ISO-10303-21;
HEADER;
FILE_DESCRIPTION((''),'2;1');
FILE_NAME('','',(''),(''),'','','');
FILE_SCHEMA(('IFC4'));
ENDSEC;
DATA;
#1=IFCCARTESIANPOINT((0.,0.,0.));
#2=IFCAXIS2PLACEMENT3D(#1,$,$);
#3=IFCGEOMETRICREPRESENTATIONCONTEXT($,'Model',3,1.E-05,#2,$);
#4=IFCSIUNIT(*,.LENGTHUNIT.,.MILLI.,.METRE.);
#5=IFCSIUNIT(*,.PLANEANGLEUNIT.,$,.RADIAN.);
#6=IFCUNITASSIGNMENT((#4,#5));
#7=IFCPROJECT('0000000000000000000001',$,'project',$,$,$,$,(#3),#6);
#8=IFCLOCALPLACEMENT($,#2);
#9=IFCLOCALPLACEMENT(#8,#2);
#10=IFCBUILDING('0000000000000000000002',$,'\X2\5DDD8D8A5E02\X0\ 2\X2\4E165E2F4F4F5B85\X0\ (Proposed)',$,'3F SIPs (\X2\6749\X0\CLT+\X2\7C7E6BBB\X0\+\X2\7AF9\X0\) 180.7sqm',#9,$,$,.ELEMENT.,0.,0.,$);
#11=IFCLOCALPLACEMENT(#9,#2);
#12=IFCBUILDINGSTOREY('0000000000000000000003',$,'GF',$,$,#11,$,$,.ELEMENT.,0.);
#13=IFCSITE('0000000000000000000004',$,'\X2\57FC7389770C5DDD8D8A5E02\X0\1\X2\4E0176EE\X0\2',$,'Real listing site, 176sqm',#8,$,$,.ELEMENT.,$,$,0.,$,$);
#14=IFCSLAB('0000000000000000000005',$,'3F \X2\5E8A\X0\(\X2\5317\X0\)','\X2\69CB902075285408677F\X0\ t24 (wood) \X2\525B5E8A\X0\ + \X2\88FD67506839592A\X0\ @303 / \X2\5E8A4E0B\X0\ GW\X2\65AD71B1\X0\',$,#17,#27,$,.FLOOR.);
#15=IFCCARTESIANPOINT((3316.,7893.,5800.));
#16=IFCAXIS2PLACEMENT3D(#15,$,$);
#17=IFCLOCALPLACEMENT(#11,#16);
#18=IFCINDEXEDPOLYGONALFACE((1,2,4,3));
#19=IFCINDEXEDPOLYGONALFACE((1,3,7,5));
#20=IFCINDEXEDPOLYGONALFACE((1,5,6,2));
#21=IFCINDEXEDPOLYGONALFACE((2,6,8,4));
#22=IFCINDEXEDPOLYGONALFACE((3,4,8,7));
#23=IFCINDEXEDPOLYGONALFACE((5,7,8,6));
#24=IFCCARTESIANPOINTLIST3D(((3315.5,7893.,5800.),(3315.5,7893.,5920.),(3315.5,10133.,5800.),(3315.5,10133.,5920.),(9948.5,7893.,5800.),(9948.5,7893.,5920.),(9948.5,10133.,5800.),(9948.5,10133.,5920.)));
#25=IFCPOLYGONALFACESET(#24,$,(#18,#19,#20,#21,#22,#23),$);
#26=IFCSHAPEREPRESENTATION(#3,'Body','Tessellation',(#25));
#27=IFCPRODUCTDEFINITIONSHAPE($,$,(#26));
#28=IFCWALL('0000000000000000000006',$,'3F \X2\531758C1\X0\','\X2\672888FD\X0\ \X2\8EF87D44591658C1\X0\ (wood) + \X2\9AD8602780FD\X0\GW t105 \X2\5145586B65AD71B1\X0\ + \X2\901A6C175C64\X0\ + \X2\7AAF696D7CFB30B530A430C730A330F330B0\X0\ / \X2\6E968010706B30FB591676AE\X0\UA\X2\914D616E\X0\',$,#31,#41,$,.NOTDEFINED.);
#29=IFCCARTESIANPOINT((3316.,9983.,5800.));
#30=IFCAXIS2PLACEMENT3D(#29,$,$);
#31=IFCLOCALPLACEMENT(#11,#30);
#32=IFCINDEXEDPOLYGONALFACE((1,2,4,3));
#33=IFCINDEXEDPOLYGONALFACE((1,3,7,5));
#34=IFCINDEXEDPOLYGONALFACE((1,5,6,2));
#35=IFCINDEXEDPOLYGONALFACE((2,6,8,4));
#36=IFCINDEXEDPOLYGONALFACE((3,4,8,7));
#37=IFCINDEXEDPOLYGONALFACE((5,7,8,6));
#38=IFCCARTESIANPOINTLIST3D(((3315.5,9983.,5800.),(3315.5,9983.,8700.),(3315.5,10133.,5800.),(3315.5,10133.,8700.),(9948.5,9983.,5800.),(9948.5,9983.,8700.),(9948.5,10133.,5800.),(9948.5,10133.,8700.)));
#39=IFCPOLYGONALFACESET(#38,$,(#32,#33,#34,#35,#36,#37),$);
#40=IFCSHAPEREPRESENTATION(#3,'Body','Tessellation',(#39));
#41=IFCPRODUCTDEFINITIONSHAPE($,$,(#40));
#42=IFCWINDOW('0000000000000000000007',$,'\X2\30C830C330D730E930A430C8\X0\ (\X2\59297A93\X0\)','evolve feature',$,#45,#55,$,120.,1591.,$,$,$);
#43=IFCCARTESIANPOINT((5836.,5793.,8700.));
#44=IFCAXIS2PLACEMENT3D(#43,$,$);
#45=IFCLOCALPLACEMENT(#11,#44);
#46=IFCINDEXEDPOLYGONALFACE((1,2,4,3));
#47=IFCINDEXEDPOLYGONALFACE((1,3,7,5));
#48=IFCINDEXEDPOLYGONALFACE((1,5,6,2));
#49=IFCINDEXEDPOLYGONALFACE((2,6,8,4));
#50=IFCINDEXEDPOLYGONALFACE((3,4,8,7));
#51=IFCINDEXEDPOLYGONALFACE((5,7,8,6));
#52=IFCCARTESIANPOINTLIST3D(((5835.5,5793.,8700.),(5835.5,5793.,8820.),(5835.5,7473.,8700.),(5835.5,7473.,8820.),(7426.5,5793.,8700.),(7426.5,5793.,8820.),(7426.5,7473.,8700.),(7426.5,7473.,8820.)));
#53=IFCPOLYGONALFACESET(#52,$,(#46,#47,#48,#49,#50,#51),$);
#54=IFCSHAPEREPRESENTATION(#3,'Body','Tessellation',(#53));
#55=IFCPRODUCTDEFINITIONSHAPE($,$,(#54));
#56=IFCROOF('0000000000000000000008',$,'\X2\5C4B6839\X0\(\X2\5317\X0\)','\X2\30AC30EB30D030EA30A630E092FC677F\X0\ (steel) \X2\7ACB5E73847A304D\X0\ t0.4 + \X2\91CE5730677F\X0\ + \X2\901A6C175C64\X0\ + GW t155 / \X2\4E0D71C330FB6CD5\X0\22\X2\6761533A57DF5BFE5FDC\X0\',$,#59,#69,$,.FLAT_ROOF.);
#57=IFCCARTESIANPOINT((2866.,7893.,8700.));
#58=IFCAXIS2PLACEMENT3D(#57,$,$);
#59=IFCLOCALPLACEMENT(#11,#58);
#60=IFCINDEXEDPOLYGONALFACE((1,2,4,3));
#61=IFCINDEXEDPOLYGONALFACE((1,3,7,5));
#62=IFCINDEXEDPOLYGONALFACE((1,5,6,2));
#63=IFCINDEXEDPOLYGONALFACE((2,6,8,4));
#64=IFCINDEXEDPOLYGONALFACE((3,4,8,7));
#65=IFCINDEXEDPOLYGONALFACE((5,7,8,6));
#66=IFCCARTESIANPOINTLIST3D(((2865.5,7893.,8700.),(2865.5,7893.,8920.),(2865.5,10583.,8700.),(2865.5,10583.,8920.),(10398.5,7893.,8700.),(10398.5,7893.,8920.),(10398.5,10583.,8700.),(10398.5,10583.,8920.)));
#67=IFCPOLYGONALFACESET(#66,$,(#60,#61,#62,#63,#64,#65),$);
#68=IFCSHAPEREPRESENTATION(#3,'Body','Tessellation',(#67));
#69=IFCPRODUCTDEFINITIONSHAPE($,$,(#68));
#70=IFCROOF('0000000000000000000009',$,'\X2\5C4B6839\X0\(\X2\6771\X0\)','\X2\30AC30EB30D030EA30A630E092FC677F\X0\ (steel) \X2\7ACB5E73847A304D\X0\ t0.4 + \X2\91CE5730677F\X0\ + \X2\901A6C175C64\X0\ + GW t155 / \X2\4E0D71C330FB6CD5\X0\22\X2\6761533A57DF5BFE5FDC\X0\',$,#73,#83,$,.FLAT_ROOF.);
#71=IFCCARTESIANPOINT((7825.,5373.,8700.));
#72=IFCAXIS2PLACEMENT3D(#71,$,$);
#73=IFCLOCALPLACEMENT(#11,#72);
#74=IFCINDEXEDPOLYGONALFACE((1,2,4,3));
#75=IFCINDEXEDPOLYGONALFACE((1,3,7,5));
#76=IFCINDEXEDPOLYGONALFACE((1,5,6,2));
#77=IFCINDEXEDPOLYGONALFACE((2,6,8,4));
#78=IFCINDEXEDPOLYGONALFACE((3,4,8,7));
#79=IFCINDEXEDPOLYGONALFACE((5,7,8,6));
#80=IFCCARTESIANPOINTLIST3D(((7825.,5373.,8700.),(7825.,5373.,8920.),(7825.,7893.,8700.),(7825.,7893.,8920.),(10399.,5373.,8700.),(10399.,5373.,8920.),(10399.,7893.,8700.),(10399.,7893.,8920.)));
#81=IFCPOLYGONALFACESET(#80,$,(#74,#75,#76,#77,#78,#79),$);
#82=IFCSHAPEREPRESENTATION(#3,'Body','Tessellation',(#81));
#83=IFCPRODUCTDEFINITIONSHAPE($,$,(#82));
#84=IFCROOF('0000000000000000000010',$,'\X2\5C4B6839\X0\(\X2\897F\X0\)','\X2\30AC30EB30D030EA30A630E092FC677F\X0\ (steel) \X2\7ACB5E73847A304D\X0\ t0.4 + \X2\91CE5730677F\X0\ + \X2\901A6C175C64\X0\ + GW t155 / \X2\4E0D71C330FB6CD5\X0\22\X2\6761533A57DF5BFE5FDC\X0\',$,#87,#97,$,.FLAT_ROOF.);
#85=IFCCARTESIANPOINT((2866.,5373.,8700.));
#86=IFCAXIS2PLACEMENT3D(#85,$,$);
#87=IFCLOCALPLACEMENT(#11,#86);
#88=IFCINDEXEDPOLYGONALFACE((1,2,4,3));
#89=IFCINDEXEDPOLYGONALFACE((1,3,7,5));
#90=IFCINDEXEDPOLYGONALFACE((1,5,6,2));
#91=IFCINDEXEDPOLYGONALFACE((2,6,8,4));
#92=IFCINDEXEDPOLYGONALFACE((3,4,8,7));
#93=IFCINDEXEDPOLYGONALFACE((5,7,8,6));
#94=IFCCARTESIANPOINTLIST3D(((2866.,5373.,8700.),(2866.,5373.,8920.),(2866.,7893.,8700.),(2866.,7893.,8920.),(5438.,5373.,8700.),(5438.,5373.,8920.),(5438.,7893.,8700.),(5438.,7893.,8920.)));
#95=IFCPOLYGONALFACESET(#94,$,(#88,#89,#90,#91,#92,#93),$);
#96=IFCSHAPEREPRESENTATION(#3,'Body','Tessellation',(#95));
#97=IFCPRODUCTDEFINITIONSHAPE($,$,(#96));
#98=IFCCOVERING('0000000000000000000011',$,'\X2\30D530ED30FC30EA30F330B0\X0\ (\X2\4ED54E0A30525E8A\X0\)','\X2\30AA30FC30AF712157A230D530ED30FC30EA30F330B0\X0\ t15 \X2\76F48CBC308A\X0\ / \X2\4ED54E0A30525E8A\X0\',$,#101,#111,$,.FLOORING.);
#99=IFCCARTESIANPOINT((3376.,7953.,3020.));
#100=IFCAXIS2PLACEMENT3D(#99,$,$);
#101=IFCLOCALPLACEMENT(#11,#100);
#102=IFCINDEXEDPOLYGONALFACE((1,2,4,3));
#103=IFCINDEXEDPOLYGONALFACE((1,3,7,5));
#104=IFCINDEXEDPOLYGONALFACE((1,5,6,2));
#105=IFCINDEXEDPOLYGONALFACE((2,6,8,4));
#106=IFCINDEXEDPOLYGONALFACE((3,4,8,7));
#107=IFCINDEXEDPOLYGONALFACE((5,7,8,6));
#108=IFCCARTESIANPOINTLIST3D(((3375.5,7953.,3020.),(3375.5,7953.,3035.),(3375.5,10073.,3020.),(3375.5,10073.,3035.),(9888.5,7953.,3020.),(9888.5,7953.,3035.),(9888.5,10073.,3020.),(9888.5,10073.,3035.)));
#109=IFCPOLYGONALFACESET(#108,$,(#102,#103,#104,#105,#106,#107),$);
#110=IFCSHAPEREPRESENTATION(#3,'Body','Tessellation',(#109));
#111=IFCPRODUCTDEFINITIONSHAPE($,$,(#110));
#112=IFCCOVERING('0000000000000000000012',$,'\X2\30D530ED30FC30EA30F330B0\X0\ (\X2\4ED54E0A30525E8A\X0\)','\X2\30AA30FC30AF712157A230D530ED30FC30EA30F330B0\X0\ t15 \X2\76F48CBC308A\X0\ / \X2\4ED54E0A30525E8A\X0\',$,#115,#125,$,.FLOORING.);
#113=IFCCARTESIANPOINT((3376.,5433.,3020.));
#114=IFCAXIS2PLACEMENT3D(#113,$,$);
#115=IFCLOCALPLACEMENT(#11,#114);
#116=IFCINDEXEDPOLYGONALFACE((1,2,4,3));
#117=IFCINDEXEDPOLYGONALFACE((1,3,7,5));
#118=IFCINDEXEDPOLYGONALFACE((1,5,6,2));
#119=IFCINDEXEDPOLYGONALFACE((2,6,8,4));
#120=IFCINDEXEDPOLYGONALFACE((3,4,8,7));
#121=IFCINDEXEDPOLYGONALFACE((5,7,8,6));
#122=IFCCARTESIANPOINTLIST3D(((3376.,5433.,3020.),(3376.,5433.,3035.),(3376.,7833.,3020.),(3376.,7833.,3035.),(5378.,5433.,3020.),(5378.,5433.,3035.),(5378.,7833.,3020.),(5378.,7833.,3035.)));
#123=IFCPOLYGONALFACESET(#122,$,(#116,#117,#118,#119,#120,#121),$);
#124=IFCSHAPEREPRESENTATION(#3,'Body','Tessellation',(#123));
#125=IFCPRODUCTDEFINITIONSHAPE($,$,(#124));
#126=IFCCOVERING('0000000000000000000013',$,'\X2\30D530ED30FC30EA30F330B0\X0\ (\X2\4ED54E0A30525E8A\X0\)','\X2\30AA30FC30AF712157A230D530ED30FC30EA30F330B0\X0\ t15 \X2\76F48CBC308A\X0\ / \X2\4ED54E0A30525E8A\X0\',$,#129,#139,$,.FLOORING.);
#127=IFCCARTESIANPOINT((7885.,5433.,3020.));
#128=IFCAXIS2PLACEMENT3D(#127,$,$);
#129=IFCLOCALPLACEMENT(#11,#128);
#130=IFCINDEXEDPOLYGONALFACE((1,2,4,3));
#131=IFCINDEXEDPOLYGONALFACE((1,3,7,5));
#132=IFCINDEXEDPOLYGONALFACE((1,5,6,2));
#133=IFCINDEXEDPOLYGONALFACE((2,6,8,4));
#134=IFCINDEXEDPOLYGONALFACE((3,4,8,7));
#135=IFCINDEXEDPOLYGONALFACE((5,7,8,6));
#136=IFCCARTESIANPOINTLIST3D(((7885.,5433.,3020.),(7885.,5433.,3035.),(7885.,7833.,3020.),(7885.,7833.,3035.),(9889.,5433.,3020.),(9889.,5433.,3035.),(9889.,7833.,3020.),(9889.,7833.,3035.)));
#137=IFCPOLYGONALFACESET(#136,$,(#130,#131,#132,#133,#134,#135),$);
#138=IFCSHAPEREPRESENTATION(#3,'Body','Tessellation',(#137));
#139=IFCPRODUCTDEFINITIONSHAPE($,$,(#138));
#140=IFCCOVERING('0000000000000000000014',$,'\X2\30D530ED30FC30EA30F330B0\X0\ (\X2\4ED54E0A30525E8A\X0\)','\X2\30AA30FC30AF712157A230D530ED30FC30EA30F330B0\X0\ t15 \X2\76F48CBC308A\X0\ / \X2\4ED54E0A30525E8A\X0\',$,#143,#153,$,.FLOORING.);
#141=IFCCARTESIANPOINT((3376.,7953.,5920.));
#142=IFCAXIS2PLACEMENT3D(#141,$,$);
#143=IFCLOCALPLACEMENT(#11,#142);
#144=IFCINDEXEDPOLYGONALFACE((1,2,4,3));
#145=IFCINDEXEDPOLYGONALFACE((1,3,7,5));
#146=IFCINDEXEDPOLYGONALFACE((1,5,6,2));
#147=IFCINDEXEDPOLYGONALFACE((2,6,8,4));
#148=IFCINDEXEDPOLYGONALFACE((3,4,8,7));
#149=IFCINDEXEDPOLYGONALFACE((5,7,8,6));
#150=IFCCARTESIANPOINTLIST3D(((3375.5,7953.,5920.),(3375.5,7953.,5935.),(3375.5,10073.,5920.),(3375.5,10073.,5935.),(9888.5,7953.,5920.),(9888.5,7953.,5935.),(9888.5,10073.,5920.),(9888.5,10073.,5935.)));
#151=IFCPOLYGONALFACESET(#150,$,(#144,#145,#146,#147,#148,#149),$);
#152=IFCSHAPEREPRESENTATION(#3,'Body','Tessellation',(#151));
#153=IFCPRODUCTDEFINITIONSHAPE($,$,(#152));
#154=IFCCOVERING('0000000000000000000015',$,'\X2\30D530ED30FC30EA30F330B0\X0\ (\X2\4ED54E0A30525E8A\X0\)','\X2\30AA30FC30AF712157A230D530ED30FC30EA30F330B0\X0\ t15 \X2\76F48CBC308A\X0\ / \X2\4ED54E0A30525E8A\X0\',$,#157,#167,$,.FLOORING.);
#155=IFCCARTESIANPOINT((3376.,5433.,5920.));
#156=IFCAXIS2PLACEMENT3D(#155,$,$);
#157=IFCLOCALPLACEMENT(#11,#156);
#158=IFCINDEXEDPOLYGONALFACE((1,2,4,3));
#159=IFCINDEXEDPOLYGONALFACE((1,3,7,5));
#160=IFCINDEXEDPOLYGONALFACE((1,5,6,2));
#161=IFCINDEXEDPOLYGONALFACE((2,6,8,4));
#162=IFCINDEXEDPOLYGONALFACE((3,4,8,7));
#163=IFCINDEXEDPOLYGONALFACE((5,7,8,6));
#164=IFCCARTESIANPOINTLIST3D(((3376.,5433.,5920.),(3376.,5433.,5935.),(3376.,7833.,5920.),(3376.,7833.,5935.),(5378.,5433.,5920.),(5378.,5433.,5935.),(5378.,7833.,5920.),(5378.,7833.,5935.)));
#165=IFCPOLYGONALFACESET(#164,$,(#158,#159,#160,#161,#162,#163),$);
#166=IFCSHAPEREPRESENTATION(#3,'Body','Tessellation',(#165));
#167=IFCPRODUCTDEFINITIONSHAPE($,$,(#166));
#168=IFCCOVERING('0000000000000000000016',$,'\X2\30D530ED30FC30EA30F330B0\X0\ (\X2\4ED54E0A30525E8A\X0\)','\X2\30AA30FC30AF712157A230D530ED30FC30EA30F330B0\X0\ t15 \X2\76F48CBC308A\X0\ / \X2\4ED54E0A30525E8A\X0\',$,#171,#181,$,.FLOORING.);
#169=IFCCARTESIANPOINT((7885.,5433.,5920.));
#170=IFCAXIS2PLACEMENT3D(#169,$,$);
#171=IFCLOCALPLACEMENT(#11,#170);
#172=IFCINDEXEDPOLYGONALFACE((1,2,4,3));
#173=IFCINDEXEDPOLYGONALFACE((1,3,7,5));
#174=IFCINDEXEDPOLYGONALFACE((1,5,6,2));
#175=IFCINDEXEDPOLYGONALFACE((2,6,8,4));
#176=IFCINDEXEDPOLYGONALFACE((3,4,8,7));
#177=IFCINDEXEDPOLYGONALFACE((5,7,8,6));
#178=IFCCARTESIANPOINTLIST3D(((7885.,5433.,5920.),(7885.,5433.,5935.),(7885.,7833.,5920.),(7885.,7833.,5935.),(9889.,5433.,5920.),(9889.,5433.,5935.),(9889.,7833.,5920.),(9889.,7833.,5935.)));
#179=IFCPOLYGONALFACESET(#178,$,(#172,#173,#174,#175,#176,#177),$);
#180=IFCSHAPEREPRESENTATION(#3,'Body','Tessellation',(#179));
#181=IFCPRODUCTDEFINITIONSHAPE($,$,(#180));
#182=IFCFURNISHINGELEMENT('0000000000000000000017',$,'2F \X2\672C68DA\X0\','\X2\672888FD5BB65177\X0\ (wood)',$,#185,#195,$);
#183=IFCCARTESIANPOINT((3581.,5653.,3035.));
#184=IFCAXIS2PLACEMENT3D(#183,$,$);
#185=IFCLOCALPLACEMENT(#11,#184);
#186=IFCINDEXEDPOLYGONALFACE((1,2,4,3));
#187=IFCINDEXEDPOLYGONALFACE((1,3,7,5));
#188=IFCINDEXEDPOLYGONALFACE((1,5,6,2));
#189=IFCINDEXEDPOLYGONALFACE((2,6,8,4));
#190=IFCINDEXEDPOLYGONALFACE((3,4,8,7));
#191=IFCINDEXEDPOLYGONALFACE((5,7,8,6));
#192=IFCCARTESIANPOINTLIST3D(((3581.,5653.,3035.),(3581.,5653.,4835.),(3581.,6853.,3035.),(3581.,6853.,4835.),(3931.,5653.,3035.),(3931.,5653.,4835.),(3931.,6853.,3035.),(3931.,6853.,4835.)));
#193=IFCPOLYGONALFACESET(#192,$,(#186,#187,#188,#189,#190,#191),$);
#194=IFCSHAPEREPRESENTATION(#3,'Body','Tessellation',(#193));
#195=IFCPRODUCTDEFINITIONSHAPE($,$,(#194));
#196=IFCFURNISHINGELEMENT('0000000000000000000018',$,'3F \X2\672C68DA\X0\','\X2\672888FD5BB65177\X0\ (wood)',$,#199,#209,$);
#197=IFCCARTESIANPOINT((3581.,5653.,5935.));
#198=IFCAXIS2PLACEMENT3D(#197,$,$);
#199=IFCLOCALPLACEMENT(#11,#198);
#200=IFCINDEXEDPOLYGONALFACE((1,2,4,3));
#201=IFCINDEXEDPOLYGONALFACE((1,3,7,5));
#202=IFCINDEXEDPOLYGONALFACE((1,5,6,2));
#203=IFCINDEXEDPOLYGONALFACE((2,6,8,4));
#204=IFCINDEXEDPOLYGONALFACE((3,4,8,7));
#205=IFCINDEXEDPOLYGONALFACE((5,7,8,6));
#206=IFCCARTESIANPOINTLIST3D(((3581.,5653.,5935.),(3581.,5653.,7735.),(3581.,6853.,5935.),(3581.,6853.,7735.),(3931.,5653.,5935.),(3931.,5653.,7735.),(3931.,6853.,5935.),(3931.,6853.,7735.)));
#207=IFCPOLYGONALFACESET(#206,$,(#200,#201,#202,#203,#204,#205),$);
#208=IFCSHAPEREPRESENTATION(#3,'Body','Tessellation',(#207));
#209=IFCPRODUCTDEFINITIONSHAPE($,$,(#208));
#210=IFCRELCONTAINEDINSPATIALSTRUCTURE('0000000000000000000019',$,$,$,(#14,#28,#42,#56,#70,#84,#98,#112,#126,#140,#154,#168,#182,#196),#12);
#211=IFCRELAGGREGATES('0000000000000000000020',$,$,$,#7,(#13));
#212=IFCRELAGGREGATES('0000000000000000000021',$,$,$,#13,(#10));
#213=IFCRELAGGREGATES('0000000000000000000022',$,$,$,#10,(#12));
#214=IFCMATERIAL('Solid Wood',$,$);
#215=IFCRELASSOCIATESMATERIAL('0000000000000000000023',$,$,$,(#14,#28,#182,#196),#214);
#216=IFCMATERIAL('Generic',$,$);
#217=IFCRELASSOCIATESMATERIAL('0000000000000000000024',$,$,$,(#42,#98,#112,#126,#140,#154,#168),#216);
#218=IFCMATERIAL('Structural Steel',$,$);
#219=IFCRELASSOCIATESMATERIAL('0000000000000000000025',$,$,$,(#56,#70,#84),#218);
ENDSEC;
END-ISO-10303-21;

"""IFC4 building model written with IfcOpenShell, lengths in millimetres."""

from ifc_helpers import new_model, si_unit, frame, frame_2d, origin, place, context, project, spatial, rectangle, extrude, material, element, save


model = new_model("IFC4")

# Units and contexts
model_context = context("Model", 3, precision=1e-05, world=origin())
ifc_project = project(units=[si_unit("LENGTHUNIT", "METRE", prefix="MILLI"), si_unit("PLANEANGLEUNIT", "RADIAN")], contexts=[model_context])

# Site, building, storey
site_placement = place(None, origin())
site = spatial("IfcSite", under=ifc_project, at=site_placement, Name="埼玉県川越市1丁目2", ObjectType="Real listing site, 176sqm", CompositionType="ELEMENT", RefElevation=0.0)
building_placement = place(site_placement, origin())
building = spatial("IfcBuilding", under=site, at=building_placement, Name="川越市 2世帯住宅 (Proposed)", ObjectType="3F SIPs (杉CLT+籾殻+竹) 180.7sqm", CompositionType="ELEMENT", ElevationOfRefHeight=0.0, ElevationOfTerrain=0.0)
storey_placement = place(building_placement, origin())
storey = spatial("IfcBuildingStorey", under=building, at=storey_placement, Name="GF", CompositionType="ELEMENT", Elevation=0.0)

# Slab
ifc_material_1 = material(Name="Solid Wood")
slab_placement = place(storey_placement, frame((3316.0, 7893.0, 5800.0)))
element("IfcSlab", 1, at=slab_placement, inside=storey, material=ifc_material_1, Name="3F 床(北)", Description="構造用合板 t24 (wood) 剛床 + 製材根太 @303 / 床下 GW断熱", PredefinedType="FLOOR", context=model_context, shape_type="SweptSolid", body=[
    extrude(rectangle(XDim=6633.0, YDim=2240.0, at=frame_2d((3316.0, 1120.0))), frame((3316.0, 7893.0, 5800.0)), (0.0, 0.0, 1.0), 120.0),
])

# Wall
wall_1_placement = place(storey_placement, frame((3316.0, 9983.0, 5800.0)))
element("IfcWall", 2, at=wall_1_placement, inside=storey, material=ifc_material_1, Name="3F 北壁", Description="木製 軸組外壁 (wood) + 高性能GW t105 充填断熱 + 通気層 + 窯業系サイディング / 準耐火・外皮UA配慮", PredefinedType="NOTDEFINED", context=model_context, shape_type="SweptSolid", body=[
    extrude(rectangle(XDim=6633.0, YDim=150.0, at=frame_2d((3316.0, 75.0))), frame((3316.0, 9983.0, 5800.0)), (0.0, 0.0, 1.0), 2900.0),
])

# Window
ifc_material_2 = material(Name="Generic")
window_1_placement = place(storey_placement, frame((5836.0, 5793.0, 8700.0)))
element("IfcWindow", 3, at=window_1_placement, inside=storey, material=ifc_material_2, Name="トップライト (天窓)", Description="evolve feature", OverallHeight=120.0, OverallWidth=1591.0, context=model_context, shape_type="SweptSolid", body=[
    extrude(rectangle(XDim=1591.0, YDim=1680.0, at=frame_2d((795.0, 840.0))), frame((5836.0, 5793.0, 8700.0)), (0.0, 0.0, 1.0), 120.0),
])

# Roofs
ifc_material_3 = material(Name="Structural Steel")
roof_1_placement = place(storey_placement, frame((2866.0, 7893.0, 8700.0)))
element("IfcRoof", 4, at=roof_1_placement, inside=storey, material=ifc_material_3, Name="屋根(北)", Description="ガルバリウム鋼板 (steel) 立平葺き t0.4 + 野地板 + 通気層 + GW t155 / 不燃・法22条区域対応", PredefinedType="FLAT_ROOF", context=model_context, shape_type="SweptSolid", body=[
    extrude(rectangle(XDim=7533.0, YDim=2690.0, at=frame_2d((3766.0, 1345.0))), frame((2866.0, 7893.0, 8700.0)), (0.0, 0.0, 1.0), 220.0),
])
roof_2_placement = place(storey_placement, frame((7825.0, 5373.0, 8700.0)))
element("IfcRoof", 5, at=roof_2_placement, inside=storey, material=ifc_material_3, Name="屋根(東)", Description="ガルバリウム鋼板 (steel) 立平葺き t0.4 + 野地板 + 通気層 + GW t155 / 不燃・法22条区域対応", PredefinedType="FLAT_ROOF", context=model_context, shape_type="SweptSolid", body=[
    extrude(rectangle(XDim=2574.0, YDim=2520.0, at=frame_2d((1287.0, 1260.0))), frame((7825.0, 5373.0, 8700.0)), (0.0, 0.0, 1.0), 220.0),
])
roof_3_placement = place(storey_placement, frame((2866.0, 5373.0, 8700.0)))
element("IfcRoof", 6, at=roof_3_placement, inside=storey, material=ifc_material_3, Name="屋根(西)", Description="ガルバリウム鋼板 (steel) 立平葺き t0.4 + 野地板 + 通気層 + GW t155 / 不燃・法22条区域対応", PredefinedType="FLAT_ROOF", context=model_context, shape_type="SweptSolid", body=[
    extrude(rectangle(XDim=2572.0, YDim=2520.0, at=frame_2d((1286.0, 1260.0))), frame((2866.0, 5373.0, 8700.0)), (0.0, 0.0, 1.0), 220.0),
])

# Coverings
covering_1_placement = place(storey_placement, frame((3376.0, 7953.0, 3020.0)))
element("IfcCovering", 7, at=covering_1_placement, inside=storey, material=ifc_material_2, Name="フローリング (仕上げ床)", Description="オーク無垢フローリング t15 直貼り / 仕上げ床", PredefinedType="FLOORING", context=model_context, shape_type="SweptSolid", body=[
    extrude(rectangle(XDim=6513.0, YDim=2120.0, at=frame_2d((3256.0, 1060.0))), frame((3376.0, 7953.0, 3020.0)), (0.0, 0.0, 1.0), 15.0),
])
covering_2_placement = place(storey_placement, frame((3376.0, 5433.0, 3020.0)))
element("IfcCovering", 8, at=covering_2_placement, inside=storey, material=ifc_material_2, Name="フローリング (仕上げ床)", Description="オーク無垢フローリング t15 直貼り / 仕上げ床", PredefinedType="FLOORING", context=model_context, shape_type="SweptSolid", body=[
    extrude(rectangle(XDim=2002.0, YDim=2400.0, at=frame_2d((1001.0, 1200.0))), frame((3376.0, 5433.0, 3020.0)), (0.0, 0.0, 1.0), 15.0),
])
covering_3_placement = place(storey_placement, frame((7885.0, 5433.0, 3020.0)))
element("IfcCovering", 9, at=covering_3_placement, inside=storey, material=ifc_material_2, Name="フローリング (仕上げ床)", Description="オーク無垢フローリング t15 直貼り / 仕上げ床", PredefinedType="FLOORING", context=model_context, shape_type="SweptSolid", body=[
    extrude(rectangle(XDim=2004.0, YDim=2400.0, at=frame_2d((1002.0, 1200.0))), frame((7885.0, 5433.0, 3020.0)), (0.0, 0.0, 1.0), 15.0),
])
covering_4_placement = place(storey_placement, frame((3376.0, 7953.0, 5920.0)))
element("IfcCovering", 10, at=covering_4_placement, inside=storey, material=ifc_material_2, Name="フローリング (仕上げ床)", Description="オーク無垢フローリング t15 直貼り / 仕上げ床", PredefinedType="FLOORING", context=model_context, shape_type="SweptSolid", body=[
    extrude(rectangle(XDim=6513.0, YDim=2120.0, at=frame_2d((3256.0, 1060.0))), frame((3376.0, 7953.0, 5920.0)), (0.0, 0.0, 1.0), 15.0),
])
covering_5_placement = place(storey_placement, frame((3376.0, 5433.0, 5920.0)))
element("IfcCovering", 11, at=covering_5_placement, inside=storey, material=ifc_material_2, Name="フローリング (仕上げ床)", Description="オーク無垢フローリング t15 直貼り / 仕上げ床", PredefinedType="FLOORING", context=model_context, shape_type="SweptSolid", body=[
    extrude(rectangle(XDim=2002.0, YDim=2400.0, at=frame_2d((1001.0, 1200.0))), frame((3376.0, 5433.0, 5920.0)), (0.0, 0.0, 1.0), 15.0),
])
covering_6_placement = place(storey_placement, frame((7885.0, 5433.0, 5920.0)))
element("IfcCovering", 12, at=covering_6_placement, inside=storey, material=ifc_material_2, Name="フローリング (仕上げ床)", Description="オーク無垢フローリング t15 直貼り / 仕上げ床", PredefinedType="FLOORING", context=model_context, shape_type="SweptSolid", body=[
    extrude(rectangle(XDim=2004.0, YDim=2400.0, at=frame_2d((1002.0, 1200.0))), frame((7885.0, 5433.0, 5920.0)), (0.0, 0.0, 1.0), 15.0),
])

# Furnishing elements
furnishing_1_placement = place(storey_placement, frame((3581.0, 5653.0, 3035.0)))
element("IfcFurnishingElement", 13, at=furnishing_1_placement, inside=storey, material=ifc_material_1, Name="2F 本棚", Description="木製家具 (wood)", context=model_context, shape_type="SweptSolid", body=[
    extrude(rectangle(XDim=350.0, YDim=1200.0, at=frame_2d((175.0, 600.0))), frame((3581.0, 5653.0, 3035.0)), (0.0, 0.0, 1.0), 1800.0),
])
furnishing_2_placement = place(storey_placement, frame((3581.0, 5653.0, 5935.0)))
element("IfcFurnishingElement", 14, at=furnishing_2_placement, inside=storey, material=ifc_material_1, Name="3F 本棚", Description="木製家具 (wood)", context=model_context, shape_type="SweptSolid", body=[
    extrude(rectangle(XDim=350.0, YDim=1200.0, at=frame_2d((175.0, 600.0))), frame((3581.0, 5653.0, 5935.0)), (0.0, 0.0, 1.0), 1800.0),
])

save(model, "model.ifc")
